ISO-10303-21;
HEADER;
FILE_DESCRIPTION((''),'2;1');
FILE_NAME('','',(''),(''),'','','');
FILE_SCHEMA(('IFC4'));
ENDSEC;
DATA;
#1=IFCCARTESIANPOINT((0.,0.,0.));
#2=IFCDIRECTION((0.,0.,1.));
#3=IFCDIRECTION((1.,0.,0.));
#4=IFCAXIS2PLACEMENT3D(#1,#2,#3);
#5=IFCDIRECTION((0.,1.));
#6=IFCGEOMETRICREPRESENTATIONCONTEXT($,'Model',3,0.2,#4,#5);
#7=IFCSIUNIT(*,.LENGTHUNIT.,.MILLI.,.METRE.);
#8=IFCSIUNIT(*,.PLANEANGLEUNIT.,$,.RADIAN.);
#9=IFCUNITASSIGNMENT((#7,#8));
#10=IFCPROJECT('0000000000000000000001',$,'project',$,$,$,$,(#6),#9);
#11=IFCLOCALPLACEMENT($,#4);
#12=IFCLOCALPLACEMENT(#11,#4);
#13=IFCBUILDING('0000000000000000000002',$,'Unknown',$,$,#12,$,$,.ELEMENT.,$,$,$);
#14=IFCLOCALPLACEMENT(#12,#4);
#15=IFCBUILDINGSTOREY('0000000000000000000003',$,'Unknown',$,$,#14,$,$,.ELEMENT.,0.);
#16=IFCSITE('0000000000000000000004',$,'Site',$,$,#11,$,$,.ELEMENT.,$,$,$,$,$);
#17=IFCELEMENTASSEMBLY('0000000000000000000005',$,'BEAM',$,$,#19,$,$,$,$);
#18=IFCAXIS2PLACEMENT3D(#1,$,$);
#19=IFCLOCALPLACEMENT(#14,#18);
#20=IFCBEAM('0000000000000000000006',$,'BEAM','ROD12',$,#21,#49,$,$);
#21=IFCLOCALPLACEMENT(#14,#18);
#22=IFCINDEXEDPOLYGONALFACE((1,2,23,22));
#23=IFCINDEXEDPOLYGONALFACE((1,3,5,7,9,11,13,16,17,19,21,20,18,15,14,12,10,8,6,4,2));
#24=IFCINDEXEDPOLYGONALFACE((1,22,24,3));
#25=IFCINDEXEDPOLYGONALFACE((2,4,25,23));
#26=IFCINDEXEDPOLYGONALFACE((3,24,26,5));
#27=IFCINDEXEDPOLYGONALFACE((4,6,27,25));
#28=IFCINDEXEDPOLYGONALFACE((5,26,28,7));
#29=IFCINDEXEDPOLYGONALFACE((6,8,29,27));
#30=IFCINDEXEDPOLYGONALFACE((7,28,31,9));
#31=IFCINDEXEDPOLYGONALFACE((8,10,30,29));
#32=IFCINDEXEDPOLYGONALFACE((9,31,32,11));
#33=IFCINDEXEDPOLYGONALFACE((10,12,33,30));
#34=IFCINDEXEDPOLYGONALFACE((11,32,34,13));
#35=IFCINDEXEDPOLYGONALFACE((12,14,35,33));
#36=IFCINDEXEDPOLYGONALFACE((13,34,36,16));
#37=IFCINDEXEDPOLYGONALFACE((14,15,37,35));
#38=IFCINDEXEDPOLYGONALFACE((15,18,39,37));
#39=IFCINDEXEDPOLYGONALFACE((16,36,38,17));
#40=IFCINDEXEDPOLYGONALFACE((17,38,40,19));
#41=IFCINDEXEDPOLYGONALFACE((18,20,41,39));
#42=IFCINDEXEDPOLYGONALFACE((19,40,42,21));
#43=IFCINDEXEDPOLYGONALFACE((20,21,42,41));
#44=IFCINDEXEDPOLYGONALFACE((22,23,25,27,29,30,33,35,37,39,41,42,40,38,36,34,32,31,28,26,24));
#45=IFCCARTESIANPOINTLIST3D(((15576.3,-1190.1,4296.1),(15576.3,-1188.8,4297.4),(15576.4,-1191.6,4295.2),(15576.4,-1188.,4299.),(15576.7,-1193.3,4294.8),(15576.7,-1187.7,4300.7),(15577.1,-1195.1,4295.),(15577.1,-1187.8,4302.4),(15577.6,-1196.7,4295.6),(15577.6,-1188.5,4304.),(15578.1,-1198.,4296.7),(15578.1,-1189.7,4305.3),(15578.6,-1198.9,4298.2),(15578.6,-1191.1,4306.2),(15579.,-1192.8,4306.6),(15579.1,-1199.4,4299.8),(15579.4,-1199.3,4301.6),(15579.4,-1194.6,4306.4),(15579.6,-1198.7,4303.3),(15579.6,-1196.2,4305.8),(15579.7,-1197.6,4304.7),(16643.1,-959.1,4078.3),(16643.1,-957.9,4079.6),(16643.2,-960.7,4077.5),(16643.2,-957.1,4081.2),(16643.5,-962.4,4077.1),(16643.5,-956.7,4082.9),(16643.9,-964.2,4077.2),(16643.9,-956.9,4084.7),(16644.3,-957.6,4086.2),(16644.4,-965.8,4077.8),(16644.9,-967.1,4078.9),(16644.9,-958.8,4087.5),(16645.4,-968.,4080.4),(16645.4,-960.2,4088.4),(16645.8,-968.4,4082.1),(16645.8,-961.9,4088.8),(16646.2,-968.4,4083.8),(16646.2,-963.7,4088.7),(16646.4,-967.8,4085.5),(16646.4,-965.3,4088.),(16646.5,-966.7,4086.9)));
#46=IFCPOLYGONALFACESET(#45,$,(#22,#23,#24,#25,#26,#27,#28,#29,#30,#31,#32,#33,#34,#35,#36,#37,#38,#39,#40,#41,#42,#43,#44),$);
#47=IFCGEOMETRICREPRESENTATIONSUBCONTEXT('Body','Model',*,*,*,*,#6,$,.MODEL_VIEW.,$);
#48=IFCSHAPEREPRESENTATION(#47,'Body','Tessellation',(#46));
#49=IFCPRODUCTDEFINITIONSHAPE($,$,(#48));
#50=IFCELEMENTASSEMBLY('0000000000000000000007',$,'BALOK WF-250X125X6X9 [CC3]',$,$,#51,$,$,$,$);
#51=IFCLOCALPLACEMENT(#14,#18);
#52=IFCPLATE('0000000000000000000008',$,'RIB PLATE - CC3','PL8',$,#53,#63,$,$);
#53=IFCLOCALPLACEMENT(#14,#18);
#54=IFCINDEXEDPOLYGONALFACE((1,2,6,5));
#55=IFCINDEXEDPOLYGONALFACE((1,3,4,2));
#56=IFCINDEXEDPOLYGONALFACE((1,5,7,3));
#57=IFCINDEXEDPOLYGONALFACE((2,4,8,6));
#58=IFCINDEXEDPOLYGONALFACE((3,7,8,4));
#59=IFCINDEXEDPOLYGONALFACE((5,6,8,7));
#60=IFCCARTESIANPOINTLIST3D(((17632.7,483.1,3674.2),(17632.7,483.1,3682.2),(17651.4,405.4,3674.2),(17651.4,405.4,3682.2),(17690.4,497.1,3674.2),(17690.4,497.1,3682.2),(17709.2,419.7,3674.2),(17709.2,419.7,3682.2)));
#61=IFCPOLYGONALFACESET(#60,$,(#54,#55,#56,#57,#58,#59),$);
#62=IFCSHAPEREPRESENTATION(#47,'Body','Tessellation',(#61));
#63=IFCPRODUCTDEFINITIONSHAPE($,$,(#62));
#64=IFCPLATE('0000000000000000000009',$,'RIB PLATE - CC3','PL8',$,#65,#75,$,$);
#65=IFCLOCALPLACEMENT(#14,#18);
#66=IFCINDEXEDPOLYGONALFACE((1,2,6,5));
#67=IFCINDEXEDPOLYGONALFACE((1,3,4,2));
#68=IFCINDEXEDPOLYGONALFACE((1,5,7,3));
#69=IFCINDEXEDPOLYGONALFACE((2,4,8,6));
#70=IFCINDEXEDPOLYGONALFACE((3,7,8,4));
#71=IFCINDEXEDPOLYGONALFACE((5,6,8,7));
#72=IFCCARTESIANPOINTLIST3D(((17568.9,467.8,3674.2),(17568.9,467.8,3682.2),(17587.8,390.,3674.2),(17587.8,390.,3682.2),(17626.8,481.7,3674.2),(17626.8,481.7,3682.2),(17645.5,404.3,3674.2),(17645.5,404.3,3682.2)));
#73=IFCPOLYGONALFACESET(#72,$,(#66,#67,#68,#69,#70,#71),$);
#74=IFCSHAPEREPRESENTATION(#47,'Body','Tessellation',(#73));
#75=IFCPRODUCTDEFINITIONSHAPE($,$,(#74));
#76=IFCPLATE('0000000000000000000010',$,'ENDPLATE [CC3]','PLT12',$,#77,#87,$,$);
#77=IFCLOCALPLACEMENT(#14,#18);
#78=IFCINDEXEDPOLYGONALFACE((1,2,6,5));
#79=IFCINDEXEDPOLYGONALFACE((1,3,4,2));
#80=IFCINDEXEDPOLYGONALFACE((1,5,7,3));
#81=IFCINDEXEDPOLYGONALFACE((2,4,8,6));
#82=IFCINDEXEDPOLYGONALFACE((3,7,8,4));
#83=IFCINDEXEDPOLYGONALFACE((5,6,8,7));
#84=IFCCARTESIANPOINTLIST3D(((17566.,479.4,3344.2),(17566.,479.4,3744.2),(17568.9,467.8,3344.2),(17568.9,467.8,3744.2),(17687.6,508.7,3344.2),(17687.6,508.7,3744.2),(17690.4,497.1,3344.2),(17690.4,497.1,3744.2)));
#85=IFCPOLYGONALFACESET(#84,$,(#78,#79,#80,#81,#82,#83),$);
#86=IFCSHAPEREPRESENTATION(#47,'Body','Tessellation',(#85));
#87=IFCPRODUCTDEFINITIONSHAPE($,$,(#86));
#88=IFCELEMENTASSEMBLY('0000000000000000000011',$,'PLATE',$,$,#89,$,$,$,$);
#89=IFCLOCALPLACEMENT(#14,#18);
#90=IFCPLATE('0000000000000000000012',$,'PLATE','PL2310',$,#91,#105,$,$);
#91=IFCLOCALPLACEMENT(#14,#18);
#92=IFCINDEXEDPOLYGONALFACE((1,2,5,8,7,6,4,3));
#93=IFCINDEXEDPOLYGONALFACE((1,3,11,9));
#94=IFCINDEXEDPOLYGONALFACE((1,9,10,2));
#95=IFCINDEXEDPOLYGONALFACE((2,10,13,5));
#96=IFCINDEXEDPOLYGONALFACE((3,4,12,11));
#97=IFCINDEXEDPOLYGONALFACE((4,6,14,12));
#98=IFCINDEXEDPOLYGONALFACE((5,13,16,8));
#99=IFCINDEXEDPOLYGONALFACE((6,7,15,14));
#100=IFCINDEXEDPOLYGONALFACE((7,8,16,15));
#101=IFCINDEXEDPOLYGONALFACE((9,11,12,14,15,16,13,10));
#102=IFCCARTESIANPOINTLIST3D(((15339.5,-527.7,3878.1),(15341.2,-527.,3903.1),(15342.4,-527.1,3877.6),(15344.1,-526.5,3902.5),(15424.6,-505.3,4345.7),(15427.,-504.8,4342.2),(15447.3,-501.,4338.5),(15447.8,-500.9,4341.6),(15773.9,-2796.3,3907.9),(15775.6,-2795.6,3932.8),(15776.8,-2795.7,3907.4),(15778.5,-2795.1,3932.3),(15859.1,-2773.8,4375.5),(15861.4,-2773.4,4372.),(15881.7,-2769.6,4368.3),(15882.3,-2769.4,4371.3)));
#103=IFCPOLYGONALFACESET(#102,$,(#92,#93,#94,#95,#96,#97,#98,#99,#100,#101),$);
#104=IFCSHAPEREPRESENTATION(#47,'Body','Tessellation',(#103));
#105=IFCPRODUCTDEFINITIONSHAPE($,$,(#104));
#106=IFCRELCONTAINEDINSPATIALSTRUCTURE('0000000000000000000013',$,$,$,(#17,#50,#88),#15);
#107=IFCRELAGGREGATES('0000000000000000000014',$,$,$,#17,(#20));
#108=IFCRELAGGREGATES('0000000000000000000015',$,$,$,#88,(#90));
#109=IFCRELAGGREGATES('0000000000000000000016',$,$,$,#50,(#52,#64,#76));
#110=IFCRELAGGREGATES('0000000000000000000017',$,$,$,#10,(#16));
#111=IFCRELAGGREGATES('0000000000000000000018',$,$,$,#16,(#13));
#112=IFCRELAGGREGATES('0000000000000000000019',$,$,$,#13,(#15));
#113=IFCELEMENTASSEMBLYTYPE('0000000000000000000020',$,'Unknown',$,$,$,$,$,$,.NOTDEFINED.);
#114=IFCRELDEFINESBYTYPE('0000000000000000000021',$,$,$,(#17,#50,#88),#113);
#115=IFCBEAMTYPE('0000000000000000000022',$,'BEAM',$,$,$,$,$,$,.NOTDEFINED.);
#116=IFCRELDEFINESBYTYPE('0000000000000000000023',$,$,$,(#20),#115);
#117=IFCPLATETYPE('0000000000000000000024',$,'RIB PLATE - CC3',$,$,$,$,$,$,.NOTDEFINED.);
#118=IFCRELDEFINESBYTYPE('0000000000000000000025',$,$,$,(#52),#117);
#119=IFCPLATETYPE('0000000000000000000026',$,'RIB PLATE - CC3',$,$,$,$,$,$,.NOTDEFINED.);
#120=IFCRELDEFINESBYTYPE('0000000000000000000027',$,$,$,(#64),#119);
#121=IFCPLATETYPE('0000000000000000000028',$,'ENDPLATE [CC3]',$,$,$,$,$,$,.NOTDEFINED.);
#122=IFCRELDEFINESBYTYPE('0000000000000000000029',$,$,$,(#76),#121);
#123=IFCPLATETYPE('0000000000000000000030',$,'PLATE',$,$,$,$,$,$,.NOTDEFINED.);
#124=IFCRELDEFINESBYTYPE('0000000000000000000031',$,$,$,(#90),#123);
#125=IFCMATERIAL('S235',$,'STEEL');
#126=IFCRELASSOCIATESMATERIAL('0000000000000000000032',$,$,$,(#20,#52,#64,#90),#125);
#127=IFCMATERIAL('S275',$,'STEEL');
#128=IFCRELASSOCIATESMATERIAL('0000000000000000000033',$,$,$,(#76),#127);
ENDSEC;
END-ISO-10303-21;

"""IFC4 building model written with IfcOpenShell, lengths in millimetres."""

from ifc_helpers import new_model, si_unit, direction, frame, origin_with_axes, origin_2d_with_axis, place, context, subcontext, project, spatial, line, indexed_curve, circle, outline, extrude, material, material_profile, profile_set, profile_usage, type_object, element, aggregate, save


model = new_model("IFC4")

# Units and contexts
model_context = context("Model", 3, precision=0.2, world=origin_with_axes(), true_north=direction((0.0, 1.0)))
body_context = subcontext(model_context, "Body", "Model", "MODEL_VIEW")
ifc_project = project(units=[si_unit("LENGTHUNIT", "METRE", prefix="MILLI"), si_unit("PLANEANGLEUNIT", "RADIAN")], contexts=[model_context])

# Site, building, storey
site_placement = place(None, origin_with_axes())
site = spatial("IfcSite", under=ifc_project, at=site_placement, Name="Site", CompositionType="ELEMENT")
building_placement = place(site_placement, origin_with_axes())
building = spatial("IfcBuilding", under=site, at=building_placement, Name="Unknown", CompositionType="ELEMENT")
storey_placement = place(building_placement, origin_with_axes())
storey = spatial("IfcBuildingStorey", under=building, at=storey_placement, Name="Unknown", CompositionType="ELEMENT", Elevation=0.0)

# Element assembly, beam
element_assembly_type = type_object("IfcElementAssemblyType", Name="Unknown", PredefinedType="NOTDEFINED")
ifc_material_1 = material(Name="S235", Category="STEEL")
ifc_material_profile_1 = material_profile(ifc_material_1, circle(Radius=6.0, at=origin_2d_with_axis()), Name="ROD12")
ifc_profile_set_1 = profile_set([ifc_material_profile_1])
ifc_profile_usage_1 = profile_usage(ifc_profile_set_1, cardinal=5)
beam_type_1 = type_object("IfcBeamType", Name="BEAM", PredefinedType="NOTDEFINED")
assembly_1_placement = place(storey_placement, frame((16644.8, -962.6, 4082.9), z_axis=(-0.211556, 0.977366, 0.0), x_axis=(-0.958473, -0.207467, 0.195673)))
assembly_1 = element("IfcElementAssembly", 1, at=assembly_1_placement, inside=storey, type_object=element_assembly_type, Name="BEAM")
beam_1_placement = place(assembly_1_placement, origin_with_axes())
beam_1 = element("IfcBeam", 2, at=beam_1_placement, type_object=beam_type_1, material=ifc_profile_usage_1, Name="BEAM", Description="ROD12", context=body_context, shape_type="SolidModel", body=[
    extrude(circle(Radius=6.0, at=origin_2d_with_axis()), frame((0.0, 0.0, 0.0), z_axis=(-1.0, 0.0, 0.0), x_axis=(0.0, 0.0, 1.0)), (0.0, 0.0, -1.0), 1113.0),
])
aggregate(assembly_1, [beam_1])

# Shared definitions
ifc_material_2 = material(Name="S275", Category="STEEL")

# Element assembly, plates
assembly_2_placement = place(storey_placement, frame((17628.6, 487.2, 3619.2), z_axis=(-0.972076, -0.234666, 0.0), x_axis=(0.234666, -0.972076, 0.0)))
assembly_2 = element("IfcElementAssembly", 3, at=assembly_2_placement, inside=storey, type_object=element_assembly_type, Name="BALOK WF-250X125X6X9 [CC3]")
ifc_material_profile_2 = material_profile(ifc_material_1, outline(indexed_curve([(0.0, 0.0), (80.0, 0.0), (79.7, 59.5), (0.0, 59.4)], segments=[line(1, 2, 3, 4, 1)])), Name="PL8")
ifc_profile_set_2 = profile_set([ifc_material_profile_2])
ifc_profile_usage_2 = profile_usage(ifc_profile_set_2, cardinal=5)
plate_type_1 = type_object("IfcPlateType", Name="RIB PLATE - CC3", PredefinedType="NOTDEFINED")
plate_1_placement = place(assembly_2_placement, frame((4.9, 59.0, -3.0), z_axis=(0.0, 1.0, 0.0), x_axis=(1.0, 0.0, 0.0)))
plate_1 = element("IfcPlate", 4, at=plate_1_placement, type_object=plate_type_1, material=ifc_profile_usage_2, Name="RIB PLATE - CC3", Description="PL8", context=body_context, shape_type="SolidModel", body=[
    extrude(outline(indexed_curve([(0.0, 0.0), (80.0, 0.0), (79.7, 59.5), (0.0, 59.4)], segments=[line(1, 2, 3, 4, 1)])), frame((0.0, 0.0, 4.0), z_axis=(0.0, 0.0, 1.0), x_axis=(1.0, 0.0, 0.0)), (0.0, 0.0, -1.0), 8.0),
])
ifc_material_profile_3 = material_profile(ifc_material_1, outline(indexed_curve([(0.0, 0.0), (80.0, 0.0), (79.8, 59.5), (0.1, 59.6)], segments=[line(1, 2, 3, 4, 1)])), Name="PL8")
ifc_profile_set_3 = profile_set([ifc_material_profile_3])
ifc_profile_usage_3 = profile_usage(ifc_profile_set_3, cardinal=5)
plate_type_2 = type_object("IfcPlateType", Name="RIB PLATE - CC3", PredefinedType="NOTDEFINED")
plate_2_placement = place(assembly_2_placement, frame((4.9, 59.0, 62.6), z_axis=(0.0, 1.0, 0.0), x_axis=(0.999999, 0.0, -0.001595)))
plate_2 = element("IfcPlate", 5, at=plate_2_placement, type_object=plate_type_2, material=ifc_profile_usage_3, Name="RIB PLATE - CC3", Description="PL8", context=body_context, shape_type="SolidModel", body=[
    extrude(outline(indexed_curve([(0.0, 0.0), (80.0, 0.0), (79.8, 59.5), (0.1, 59.6)], segments=[line(1, 2, 3, 4, 1)])), frame((0.0, 0.0, 4.0), z_axis=(0.0, 0.0, 1.0), x_axis=(1.0, 0.0, 0.0)), (0.0, 0.0, -1.0), 8.0),
])
ifc_material_profile_4 = material_profile(ifc_material_2, outline(indexed_curve([(0.0, 0.0), (125.0, 0.0), (125.0, 400.0), (0.0, 400.0)], segments=[line(1, 2, 3, 4, 1)])), Name="PLT12")
ifc_profile_set_4 = profile_set([ifc_material_profile_4])
ifc_profile_usage_4 = profile_usage(ifc_profile_set_4, cardinal=5)
plate_type_3 = type_object("IfcPlateType", Name="ENDPLATE [CC3]", PredefinedType="NOTDEFINED")
plate_3_placement = place(assembly_2_placement, frame((-1.0, 125.0, -62.4), z_axis=(1.0, 0.000022, 0.000281), x_axis=(-0.000281, 0.0, 1.0)))
plate_3 = element("IfcPlate", 6, at=plate_3_placement, type_object=plate_type_3, material=ifc_profile_usage_4, Name="ENDPLATE [CC3]", Description="PLT12", context=body_context, shape_type="SolidModel", body=[
    extrude(outline(indexed_curve([(0.0, 0.0), (125.0, 0.0), (125.0, 400.0), (0.0, 400.0)], segments=[line(1, 2, 3, 4, 1)])), frame((0.0, 0.0, 6.0), z_axis=(0.0, 0.0, 1.0), x_axis=(1.0, 0.0, 0.0)), (0.0, 0.0, -1.0), 12.0),
])

# Element assembly, plate
assembly_3_placement = place(storey_placement, frame((15665.0, -1635.2, 4356.5), z_axis=(0.188074, -0.98207, 0.012893), x_axis=(-0.967851, -0.183086, 0.172464)))
assembly_3 = element("IfcElementAssembly", 7, at=assembly_3_placement, inside=storey, type_object=element_assembly_type, Name="PLATE")
ifc_material_profile_5 = material_profile(ifc_material_1, outline(indexed_curve([(0.0, 0.0), (24.0, 0.0), (32.4, 450.9), (29.8, 475.8), (26.9, 475.8), (29.4, 450.9), (21.0, 3.0), (0.0, 3.1)], segments=[line(1, 2, 3, 4, 5, 6, 7, 8, 1)])), Name="PL2310")
ifc_profile_set_5 = profile_set([ifc_material_profile_5])
ifc_profile_usage_5 = profile_usage(ifc_profile_set_5, cardinal=5)
plate_type_4 = type_object("IfcPlateType", Name="PLATE", PredefinedType="NOTDEFINED")
plate_4_placement = place(assembly_3_placement, origin_with_axes())
plate_4 = element("IfcPlate", 8, at=plate_4_placement, type_object=plate_type_4, material=ifc_profile_usage_5, Name="PLATE", Description="PL2310", context=body_context, shape_type="SolidModel", body=[
    extrude(outline(indexed_curve([(0.0, 0.0), (24.0, 0.0), (32.4, 450.9), (29.8, 475.8), (26.9, 475.8), (29.4, 450.9), (21.0, 3.0), (0.0, 3.1)], segments=[line(1, 2, 3, 4, 5, 6, 7, 8, 1)])), frame((0.0, 0.0, 1155.0), z_axis=(0.0, 0.0, 1.0), x_axis=(1.0, 0.0, 0.0)), (0.0, 0.0, -1.0), 2310.0),
])
aggregate(assembly_3, [plate_4])

aggregate(assembly_2, [plate_1, plate_2, plate_3])

save(model, "model.ifc")
